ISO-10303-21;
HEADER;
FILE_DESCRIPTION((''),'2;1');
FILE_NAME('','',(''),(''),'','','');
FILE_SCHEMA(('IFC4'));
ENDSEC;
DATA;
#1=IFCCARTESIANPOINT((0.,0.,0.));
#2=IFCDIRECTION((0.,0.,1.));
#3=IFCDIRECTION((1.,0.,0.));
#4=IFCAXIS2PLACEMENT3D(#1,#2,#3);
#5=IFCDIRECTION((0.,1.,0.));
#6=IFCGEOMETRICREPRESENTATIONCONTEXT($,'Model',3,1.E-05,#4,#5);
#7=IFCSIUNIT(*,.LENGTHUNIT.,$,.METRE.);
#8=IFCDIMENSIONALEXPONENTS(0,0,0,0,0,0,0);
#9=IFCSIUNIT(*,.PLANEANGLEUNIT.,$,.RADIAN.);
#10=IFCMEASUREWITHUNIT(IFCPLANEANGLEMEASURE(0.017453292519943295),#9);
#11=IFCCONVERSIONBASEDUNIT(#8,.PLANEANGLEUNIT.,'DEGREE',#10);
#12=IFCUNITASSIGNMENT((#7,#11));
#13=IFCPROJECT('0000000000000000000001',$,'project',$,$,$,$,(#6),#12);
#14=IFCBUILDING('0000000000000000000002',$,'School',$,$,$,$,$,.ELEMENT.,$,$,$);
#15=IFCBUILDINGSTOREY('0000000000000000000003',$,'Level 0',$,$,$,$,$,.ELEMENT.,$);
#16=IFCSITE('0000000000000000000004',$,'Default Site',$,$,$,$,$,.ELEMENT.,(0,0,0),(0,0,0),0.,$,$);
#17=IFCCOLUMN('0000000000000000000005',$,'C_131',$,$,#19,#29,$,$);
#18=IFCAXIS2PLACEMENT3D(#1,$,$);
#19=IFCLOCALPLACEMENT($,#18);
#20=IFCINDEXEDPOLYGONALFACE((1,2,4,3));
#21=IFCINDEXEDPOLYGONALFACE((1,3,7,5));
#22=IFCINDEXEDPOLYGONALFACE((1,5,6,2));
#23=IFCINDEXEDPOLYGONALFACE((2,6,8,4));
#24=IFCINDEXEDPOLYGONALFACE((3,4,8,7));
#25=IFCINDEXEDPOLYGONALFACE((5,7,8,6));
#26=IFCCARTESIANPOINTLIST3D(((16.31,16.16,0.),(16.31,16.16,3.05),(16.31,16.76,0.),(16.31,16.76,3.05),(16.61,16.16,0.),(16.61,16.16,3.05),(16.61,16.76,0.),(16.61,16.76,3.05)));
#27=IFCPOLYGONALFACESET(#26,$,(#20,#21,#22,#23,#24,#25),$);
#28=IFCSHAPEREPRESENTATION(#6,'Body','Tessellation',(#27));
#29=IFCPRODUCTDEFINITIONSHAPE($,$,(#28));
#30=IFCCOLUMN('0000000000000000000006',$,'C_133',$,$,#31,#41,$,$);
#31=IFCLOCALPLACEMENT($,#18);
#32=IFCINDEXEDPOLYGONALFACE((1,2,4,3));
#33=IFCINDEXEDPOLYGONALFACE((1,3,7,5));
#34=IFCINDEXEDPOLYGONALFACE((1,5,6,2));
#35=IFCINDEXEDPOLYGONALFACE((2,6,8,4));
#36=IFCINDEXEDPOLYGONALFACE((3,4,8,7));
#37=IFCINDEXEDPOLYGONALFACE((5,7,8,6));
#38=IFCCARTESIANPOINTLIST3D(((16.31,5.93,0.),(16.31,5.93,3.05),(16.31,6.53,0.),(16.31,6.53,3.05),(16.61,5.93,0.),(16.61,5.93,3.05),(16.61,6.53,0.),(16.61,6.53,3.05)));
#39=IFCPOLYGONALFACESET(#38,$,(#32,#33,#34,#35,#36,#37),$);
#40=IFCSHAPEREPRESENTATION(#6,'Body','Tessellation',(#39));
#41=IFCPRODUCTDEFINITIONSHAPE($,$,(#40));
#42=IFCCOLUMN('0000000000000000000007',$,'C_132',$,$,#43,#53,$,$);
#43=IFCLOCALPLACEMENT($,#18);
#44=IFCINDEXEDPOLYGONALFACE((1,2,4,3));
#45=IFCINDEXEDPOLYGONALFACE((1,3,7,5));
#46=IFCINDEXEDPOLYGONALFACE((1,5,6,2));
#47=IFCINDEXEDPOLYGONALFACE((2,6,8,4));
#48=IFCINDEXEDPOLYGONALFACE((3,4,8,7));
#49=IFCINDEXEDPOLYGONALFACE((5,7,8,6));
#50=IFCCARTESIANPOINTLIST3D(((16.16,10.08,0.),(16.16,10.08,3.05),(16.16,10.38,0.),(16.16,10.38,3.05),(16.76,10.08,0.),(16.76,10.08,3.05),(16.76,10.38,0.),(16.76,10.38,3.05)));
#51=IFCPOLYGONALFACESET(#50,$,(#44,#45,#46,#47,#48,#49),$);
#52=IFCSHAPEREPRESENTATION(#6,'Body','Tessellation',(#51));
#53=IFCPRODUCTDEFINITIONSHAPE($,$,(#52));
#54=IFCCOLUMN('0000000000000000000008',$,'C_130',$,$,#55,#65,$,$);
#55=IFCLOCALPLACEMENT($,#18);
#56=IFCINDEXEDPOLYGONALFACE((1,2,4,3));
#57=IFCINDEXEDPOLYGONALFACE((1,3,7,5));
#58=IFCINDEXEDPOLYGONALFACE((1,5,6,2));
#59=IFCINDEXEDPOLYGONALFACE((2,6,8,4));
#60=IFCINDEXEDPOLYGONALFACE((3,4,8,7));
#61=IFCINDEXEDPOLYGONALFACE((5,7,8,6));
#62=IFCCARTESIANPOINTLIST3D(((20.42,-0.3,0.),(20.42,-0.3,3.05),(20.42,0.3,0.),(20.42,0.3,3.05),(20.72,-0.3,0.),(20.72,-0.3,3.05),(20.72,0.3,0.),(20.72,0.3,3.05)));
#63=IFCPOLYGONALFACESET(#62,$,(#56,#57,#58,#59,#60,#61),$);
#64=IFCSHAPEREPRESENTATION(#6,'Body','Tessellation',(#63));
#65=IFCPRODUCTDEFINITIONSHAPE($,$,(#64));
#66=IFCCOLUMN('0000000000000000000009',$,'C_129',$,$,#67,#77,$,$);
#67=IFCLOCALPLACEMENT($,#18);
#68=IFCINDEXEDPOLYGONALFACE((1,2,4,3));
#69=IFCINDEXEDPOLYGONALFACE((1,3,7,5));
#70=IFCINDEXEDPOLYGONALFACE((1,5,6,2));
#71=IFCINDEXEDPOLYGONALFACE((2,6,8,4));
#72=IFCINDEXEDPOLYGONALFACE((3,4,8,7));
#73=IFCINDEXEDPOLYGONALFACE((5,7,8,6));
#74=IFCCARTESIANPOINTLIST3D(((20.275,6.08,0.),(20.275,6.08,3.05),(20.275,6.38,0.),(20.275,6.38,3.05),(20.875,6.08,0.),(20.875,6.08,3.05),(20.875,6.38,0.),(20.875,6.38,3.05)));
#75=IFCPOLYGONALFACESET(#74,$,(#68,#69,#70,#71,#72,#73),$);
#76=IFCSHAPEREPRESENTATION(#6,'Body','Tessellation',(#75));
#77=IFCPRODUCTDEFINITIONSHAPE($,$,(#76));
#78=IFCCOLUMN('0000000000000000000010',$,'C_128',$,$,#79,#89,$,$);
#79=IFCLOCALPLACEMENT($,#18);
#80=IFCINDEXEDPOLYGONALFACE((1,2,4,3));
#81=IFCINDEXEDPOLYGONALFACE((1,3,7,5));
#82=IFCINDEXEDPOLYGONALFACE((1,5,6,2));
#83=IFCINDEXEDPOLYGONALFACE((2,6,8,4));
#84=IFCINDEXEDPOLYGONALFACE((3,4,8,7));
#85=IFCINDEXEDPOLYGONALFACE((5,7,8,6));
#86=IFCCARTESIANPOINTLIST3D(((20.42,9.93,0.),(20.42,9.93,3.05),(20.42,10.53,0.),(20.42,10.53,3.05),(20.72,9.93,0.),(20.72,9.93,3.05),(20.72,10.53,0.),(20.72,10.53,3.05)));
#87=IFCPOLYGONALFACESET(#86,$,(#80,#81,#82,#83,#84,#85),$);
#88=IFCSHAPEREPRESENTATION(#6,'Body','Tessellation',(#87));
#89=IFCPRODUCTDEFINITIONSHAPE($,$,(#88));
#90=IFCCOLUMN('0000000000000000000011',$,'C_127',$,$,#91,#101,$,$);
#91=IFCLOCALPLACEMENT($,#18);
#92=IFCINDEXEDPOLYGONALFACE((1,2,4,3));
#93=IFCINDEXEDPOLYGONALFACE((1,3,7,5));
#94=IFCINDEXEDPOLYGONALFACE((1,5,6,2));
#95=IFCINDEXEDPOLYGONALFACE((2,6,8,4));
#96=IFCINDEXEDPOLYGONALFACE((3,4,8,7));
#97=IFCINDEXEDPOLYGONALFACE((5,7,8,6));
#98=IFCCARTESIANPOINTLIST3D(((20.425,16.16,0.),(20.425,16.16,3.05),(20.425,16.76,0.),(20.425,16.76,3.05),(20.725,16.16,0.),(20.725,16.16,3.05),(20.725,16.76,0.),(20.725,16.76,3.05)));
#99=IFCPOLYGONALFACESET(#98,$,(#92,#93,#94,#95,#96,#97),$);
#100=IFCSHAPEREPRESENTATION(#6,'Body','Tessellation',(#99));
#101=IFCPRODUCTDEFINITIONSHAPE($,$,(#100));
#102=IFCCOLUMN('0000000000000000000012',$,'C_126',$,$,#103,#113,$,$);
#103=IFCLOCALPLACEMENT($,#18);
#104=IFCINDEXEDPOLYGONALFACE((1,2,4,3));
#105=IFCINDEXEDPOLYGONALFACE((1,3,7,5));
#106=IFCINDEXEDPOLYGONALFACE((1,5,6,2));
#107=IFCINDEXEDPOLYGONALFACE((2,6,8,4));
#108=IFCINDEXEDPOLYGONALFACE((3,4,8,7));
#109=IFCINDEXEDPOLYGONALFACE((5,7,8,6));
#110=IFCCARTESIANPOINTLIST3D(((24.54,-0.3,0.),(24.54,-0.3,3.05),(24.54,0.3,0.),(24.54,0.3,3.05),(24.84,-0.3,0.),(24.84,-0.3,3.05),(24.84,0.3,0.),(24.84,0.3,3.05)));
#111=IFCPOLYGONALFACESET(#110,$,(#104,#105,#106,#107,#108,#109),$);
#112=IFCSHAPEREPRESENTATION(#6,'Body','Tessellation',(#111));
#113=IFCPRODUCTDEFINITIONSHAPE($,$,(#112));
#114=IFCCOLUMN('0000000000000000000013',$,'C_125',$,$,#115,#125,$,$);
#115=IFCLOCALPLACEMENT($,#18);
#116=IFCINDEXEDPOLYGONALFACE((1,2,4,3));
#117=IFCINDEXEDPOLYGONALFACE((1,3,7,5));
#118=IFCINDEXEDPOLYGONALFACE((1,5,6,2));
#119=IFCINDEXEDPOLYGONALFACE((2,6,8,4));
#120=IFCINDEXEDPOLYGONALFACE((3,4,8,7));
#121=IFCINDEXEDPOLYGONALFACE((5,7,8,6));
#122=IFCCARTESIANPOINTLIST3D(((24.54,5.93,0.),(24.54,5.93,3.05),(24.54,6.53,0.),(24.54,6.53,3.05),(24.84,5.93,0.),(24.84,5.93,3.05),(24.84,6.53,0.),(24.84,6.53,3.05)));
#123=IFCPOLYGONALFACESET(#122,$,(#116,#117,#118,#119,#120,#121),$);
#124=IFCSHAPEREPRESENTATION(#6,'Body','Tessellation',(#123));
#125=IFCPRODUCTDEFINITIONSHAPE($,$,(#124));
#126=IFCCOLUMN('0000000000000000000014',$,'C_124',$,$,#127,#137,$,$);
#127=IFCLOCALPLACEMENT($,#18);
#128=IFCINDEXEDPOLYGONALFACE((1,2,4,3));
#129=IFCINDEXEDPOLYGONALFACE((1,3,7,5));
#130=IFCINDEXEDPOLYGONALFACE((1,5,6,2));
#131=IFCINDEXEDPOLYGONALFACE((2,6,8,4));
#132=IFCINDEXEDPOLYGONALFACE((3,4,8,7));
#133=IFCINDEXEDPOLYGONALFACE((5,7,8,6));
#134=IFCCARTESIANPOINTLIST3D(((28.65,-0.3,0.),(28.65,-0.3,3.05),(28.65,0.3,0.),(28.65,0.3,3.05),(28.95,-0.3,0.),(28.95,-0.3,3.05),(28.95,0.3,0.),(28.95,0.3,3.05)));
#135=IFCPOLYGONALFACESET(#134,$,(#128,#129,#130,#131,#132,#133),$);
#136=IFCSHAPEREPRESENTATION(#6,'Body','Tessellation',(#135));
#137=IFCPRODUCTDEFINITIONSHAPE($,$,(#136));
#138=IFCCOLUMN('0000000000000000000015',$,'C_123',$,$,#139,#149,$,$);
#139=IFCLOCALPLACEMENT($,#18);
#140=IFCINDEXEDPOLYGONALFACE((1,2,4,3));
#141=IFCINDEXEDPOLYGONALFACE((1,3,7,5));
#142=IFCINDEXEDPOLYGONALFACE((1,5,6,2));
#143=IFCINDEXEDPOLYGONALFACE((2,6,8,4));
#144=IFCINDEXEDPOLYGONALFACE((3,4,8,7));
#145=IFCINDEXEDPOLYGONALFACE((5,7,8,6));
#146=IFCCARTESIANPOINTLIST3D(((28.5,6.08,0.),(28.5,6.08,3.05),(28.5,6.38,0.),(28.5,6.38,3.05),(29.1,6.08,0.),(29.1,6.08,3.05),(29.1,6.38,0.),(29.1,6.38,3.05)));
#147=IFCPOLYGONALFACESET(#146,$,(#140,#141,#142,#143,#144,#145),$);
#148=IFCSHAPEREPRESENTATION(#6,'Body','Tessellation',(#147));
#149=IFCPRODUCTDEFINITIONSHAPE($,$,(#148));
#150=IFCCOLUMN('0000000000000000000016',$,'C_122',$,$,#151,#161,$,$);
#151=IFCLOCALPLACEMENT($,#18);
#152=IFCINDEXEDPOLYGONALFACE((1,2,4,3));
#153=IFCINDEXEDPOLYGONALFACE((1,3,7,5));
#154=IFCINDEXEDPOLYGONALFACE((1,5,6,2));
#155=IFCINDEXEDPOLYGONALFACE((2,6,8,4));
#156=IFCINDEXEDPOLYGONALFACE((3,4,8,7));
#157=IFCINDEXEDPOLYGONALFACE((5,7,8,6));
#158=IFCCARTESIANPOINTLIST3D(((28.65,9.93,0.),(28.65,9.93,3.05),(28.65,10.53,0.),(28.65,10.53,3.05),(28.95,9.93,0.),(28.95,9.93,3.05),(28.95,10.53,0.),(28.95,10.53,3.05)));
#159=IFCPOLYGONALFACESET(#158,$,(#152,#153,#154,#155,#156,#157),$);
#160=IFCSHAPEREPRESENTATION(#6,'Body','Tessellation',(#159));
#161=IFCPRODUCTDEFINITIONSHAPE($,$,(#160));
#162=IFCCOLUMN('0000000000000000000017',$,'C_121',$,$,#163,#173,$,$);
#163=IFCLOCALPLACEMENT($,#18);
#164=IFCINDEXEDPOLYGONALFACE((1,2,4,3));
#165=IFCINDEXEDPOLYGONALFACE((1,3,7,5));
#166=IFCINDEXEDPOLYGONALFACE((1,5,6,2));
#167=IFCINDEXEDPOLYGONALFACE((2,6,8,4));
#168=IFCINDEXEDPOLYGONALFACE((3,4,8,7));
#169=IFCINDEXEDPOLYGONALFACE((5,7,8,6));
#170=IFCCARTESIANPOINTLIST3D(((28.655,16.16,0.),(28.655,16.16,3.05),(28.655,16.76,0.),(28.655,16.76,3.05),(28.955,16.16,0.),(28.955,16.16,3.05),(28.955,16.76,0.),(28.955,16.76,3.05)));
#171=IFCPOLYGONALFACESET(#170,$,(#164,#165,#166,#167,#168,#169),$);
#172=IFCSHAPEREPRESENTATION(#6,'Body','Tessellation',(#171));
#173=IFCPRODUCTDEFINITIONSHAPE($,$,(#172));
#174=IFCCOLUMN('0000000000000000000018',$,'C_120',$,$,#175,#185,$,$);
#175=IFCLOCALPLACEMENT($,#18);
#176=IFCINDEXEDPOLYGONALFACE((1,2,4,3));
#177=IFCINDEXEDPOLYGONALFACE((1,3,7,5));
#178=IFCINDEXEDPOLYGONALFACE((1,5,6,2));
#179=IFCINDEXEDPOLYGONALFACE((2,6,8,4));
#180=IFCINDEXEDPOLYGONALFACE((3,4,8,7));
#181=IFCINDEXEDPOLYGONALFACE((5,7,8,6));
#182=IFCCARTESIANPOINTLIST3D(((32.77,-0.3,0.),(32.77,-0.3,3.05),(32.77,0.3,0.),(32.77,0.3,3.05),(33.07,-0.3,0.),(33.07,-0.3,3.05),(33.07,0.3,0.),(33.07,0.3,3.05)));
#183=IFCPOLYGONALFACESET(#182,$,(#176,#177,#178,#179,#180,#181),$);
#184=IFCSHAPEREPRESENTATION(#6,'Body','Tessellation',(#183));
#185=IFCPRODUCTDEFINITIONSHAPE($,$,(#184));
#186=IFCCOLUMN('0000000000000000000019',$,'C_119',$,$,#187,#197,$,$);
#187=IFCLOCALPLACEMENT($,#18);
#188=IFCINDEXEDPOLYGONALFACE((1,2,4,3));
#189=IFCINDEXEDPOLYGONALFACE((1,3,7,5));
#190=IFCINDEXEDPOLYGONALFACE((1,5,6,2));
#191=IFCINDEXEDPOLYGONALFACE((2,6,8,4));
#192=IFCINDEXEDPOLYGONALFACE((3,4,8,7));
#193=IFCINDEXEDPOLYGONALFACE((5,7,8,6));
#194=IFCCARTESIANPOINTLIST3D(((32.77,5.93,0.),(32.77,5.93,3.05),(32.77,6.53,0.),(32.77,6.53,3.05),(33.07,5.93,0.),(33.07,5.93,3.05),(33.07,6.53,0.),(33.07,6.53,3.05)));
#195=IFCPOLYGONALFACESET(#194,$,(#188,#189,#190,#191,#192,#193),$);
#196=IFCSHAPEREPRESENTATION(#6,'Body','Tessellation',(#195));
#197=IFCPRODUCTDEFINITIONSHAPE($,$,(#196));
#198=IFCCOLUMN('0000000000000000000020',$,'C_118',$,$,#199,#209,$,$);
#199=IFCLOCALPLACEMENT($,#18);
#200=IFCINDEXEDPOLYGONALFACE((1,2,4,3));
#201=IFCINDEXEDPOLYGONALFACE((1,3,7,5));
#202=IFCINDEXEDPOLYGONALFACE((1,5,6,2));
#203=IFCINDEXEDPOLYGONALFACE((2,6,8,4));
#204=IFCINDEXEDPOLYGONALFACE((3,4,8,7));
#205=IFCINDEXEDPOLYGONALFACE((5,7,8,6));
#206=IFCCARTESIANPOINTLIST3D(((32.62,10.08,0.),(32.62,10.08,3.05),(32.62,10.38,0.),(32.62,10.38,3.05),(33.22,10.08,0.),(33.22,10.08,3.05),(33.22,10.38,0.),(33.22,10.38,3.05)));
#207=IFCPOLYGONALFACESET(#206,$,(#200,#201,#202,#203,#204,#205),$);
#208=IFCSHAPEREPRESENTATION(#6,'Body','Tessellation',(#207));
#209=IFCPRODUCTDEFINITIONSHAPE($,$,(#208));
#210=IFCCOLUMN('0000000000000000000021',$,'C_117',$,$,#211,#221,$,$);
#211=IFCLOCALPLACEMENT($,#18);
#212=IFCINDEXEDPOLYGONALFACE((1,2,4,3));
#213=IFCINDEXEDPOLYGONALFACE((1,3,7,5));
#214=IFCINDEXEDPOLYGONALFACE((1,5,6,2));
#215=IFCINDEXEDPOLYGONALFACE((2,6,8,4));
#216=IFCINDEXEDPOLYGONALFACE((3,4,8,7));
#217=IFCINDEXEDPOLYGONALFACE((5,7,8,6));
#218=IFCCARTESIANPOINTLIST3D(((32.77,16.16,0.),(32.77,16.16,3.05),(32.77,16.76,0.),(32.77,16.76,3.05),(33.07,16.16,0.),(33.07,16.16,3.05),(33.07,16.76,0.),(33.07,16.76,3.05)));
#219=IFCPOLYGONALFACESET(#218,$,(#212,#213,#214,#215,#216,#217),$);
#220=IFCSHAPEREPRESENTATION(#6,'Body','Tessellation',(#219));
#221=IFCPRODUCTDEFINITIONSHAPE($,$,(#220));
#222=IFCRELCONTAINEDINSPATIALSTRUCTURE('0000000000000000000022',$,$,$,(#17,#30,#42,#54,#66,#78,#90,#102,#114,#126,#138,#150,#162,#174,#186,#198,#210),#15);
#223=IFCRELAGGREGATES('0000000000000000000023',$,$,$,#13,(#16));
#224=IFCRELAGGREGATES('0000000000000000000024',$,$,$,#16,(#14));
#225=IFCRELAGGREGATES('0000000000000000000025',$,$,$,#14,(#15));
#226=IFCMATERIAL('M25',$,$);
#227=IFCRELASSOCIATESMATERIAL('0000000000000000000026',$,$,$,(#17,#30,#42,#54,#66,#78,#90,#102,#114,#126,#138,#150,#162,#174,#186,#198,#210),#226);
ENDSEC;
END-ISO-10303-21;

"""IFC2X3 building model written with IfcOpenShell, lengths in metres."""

from ifc_helpers import new_model, entity, si_unit, converted_unit, direction, frame, frame_2d, origin_with_axes, place, context, project, spatial, rectangle, extrude, material, element, save


model = new_model("IFC2X3")

# Units and contexts
model_context = context("Model", 3, precision=1e-05, world=origin_with_axes(), true_north=direction((0.0, 1.0, 0.0)))
ifc_project = project(units=[si_unit("LENGTHUNIT", "METRE"), converted_unit("PLANEANGLEUNIT", "DEGREE", entity("IfcPlaneAngleMeasure", 0.017453292519943295), si_unit("PLANEANGLEUNIT", "RADIAN"), dimensions=[0, 0, 0, 0, 0, 0, 0])], contexts=[model_context])

# Site, building, storey
site = spatial("IfcSite", under=ifc_project, Name="Default Site", CompositionType="ELEMENT", RefLatitude=(0, 0, 0), RefLongitude=(0, 0, 0), RefElevation=0.0)
building = spatial("IfcBuilding", under=site, Name="School", CompositionType="ELEMENT")
storey = spatial("IfcBuildingStorey", under=building, Name="Level 0", CompositionType="ELEMENT")

# Columns
ifc_material = material(Name="M25")
placement = place(None, origin_with_axes())
element("IfcColumn", 1, at=placement, inside=storey, material=ifc_material, Name="C_131", context=model_context, shape_type="SweptSolid", body=[
    extrude(rectangle(XDim=0.3, YDim=0.6, at=frame_2d((0.0, 0.0), x_axis=(1.0, 0.0, 0.0))), frame((16.46, 16.46, 0.0), z_axis=(0.0, 0.0, 1.0), x_axis=(1.0, 0.0, 0.0)), (0.0, 0.0, 1.0), 3.05),
])
element("IfcColumn", 2, at=placement, inside=storey, material=ifc_material, Name="C_133", context=model_context, shape_type="SweptSolid", body=[
    extrude(rectangle(XDim=0.3, YDim=0.6, at=frame_2d((0.0, 0.0), x_axis=(1.0, 0.0, 0.0))), frame((16.46, 6.23, 0.0), z_axis=(0.0, 0.0, 1.0), x_axis=(1.0, 0.0, 0.0)), (0.0, 0.0, 1.0), 3.05),
])
element("IfcColumn", 3, at=placement, inside=storey, material=ifc_material, Name="C_132", context=model_context, shape_type="SweptSolid", body=[
    extrude(rectangle(XDim=0.6, YDim=0.3, at=frame_2d((0.0, 0.0), x_axis=(1.0, 0.0, 0.0))), frame((16.46, 10.23, 0.0), z_axis=(0.0, 0.0, 1.0), x_axis=(1.0, 0.0, 0.0)), (0.0, 0.0, 1.0), 3.05),
])
element("IfcColumn", 4, at=placement, inside=storey, material=ifc_material, Name="C_130", context=model_context, shape_type="SweptSolid", body=[
    extrude(rectangle(XDim=0.3, YDim=0.6, at=frame_2d((0.0, 0.0), x_axis=(1.0, 0.0, 0.0))), frame((20.57, 0.0, 0.0), z_axis=(0.0, 0.0, 1.0), x_axis=(1.0, 0.0, 0.0)), (0.0, 0.0, 1.0), 3.05),
])
element("IfcColumn", 5, at=placement, inside=storey, material=ifc_material, Name="C_129", context=model_context, shape_type="SweptSolid", body=[
    extrude(rectangle(XDim=0.6, YDim=0.3, at=frame_2d((0.0, 0.0), x_axis=(1.0, 0.0, 0.0))), frame((20.575, 6.23, 0.0), z_axis=(0.0, 0.0, 1.0), x_axis=(1.0, 0.0, 0.0)), (0.0, 0.0, 1.0), 3.05),
])
element("IfcColumn", 6, at=placement, inside=storey, material=ifc_material, Name="C_128", context=model_context, shape_type="SweptSolid", body=[
    extrude(rectangle(XDim=0.3, YDim=0.6, at=frame_2d((0.0, 0.0), x_axis=(1.0, 0.0, 0.0))), frame((20.57, 10.23, 0.0), z_axis=(0.0, 0.0, 1.0), x_axis=(1.0, 0.0, 0.0)), (0.0, 0.0, 1.0), 3.05),
])
element("IfcColumn", 7, at=placement, inside=storey, material=ifc_material, Name="C_127", context=model_context, shape_type="SweptSolid", body=[
    extrude(rectangle(XDim=0.3, YDim=0.6, at=frame_2d((0.0, 0.0), x_axis=(1.0, 0.0, 0.0))), frame((20.575, 16.46, 0.0), z_axis=(0.0, 0.0, 1.0), x_axis=(1.0, 0.0, 0.0)), (0.0, 0.0, 1.0), 3.05),
])
element("IfcColumn", 8, at=placement, inside=storey, material=ifc_material, Name="C_126", context=model_context, shape_type="SweptSolid", body=[
    extrude(rectangle(XDim=0.3, YDim=0.6, at=frame_2d((0.0, 0.0), x_axis=(1.0, 0.0, 0.0))), frame((24.69, 0.0, 0.0), z_axis=(0.0, 0.0, 1.0), x_axis=(1.0, 0.0, 0.0)), (0.0, 0.0, 1.0), 3.05),
])
element("IfcColumn", 9, at=placement, inside=storey, material=ifc_material, Name="C_125", context=model_context, shape_type="SweptSolid", body=[
    extrude(rectangle(XDim=0.3, YDim=0.6, at=frame_2d((0.0, 0.0), x_axis=(1.0, 0.0, 0.0))), frame((24.69, 6.23, 0.0), z_axis=(0.0, 0.0, 1.0), x_axis=(1.0, 0.0, 0.0)), (0.0, 0.0, 1.0), 3.05),
])
element("IfcColumn", 10, at=placement, inside=storey, material=ifc_material, Name="C_124", context=model_context, shape_type="SweptSolid", body=[
    extrude(rectangle(XDim=0.3, YDim=0.6, at=frame_2d((0.0, 0.0), x_axis=(1.0, 0.0, 0.0))), frame((28.8, 0.0, 0.0), z_axis=(0.0, 0.0, 1.0), x_axis=(1.0, 0.0, 0.0)), (0.0, 0.0, 1.0), 3.05),
])
element("IfcColumn", 11, at=placement, inside=storey, material=ifc_material, Name="C_123", context=model_context, shape_type="SweptSolid", body=[
    extrude(rectangle(XDim=0.6, YDim=0.3, at=frame_2d((0.0, 0.0), x_axis=(1.0, 0.0, 0.0))), frame((28.8, 6.23, 0.0), z_axis=(0.0, 0.0, 1.0), x_axis=(1.0, 0.0, 0.0)), (0.0, 0.0, 1.0), 3.05),
])
element("IfcColumn", 12, at=placement, inside=storey, material=ifc_material, Name="C_122", context=model_context, shape_type="SweptSolid", body=[
    extrude(rectangle(XDim=0.3, YDim=0.6, at=frame_2d((0.0, 0.0), x_axis=(1.0, 0.0, 0.0))), frame((28.8, 10.23, 0.0), z_axis=(0.0, 0.0, 1.0), x_axis=(1.0, 0.0, 0.0)), (0.0, 0.0, 1.0), 3.05),
])
element("IfcColumn", 13, at=placement, inside=storey, material=ifc_material, Name="C_121", context=model_context, shape_type="SweptSolid", body=[
    extrude(rectangle(XDim=0.3, YDim=0.6, at=frame_2d((0.0, 0.0), x_axis=(1.0, 0.0, 0.0))), frame((28.805, 16.46, 0.0), z_axis=(0.0, 0.0, 1.0), x_axis=(1.0, 0.0, 0.0)), (0.0, 0.0, 1.0), 3.05),
])
element("IfcColumn", 14, at=placement, inside=storey, material=ifc_material, Name="C_120", context=model_context, shape_type="SweptSolid", body=[
    extrude(rectangle(XDim=0.3, YDim=0.6, at=frame_2d((0.0, 0.0), x_axis=(1.0, 0.0, 0.0))), frame((32.92, 0.0, 0.0), z_axis=(0.0, 0.0, 1.0), x_axis=(1.0, 0.0, 0.0)), (0.0, 0.0, 1.0), 3.05),
])
element("IfcColumn", 15, at=placement, inside=storey, material=ifc_material, Name="C_119", context=model_context, shape_type="SweptSolid", body=[
    extrude(rectangle(XDim=0.3, YDim=0.6, at=frame_2d((0.0, 0.0), x_axis=(1.0, 0.0, 0.0))), frame((32.92, 6.23, 0.0), z_axis=(0.0, 0.0, 1.0), x_axis=(1.0, 0.0, 0.0)), (0.0, 0.0, 1.0), 3.05),
])
element("IfcColumn", 16, at=placement, inside=storey, material=ifc_material, Name="C_118", context=model_context, shape_type="SweptSolid", body=[
    extrude(rectangle(XDim=0.6, YDim=0.3, at=frame_2d((0.0, 0.0), x_axis=(1.0, 0.0, 0.0))), frame((32.92, 10.23, 0.0), z_axis=(0.0, 0.0, 1.0), x_axis=(1.0, 0.0, 0.0)), (0.0, 0.0, 1.0), 3.05),
])
element("IfcColumn", 17, at=placement, inside=storey, material=ifc_material, Name="C_117", context=model_context, shape_type="SweptSolid", body=[
    extrude(rectangle(XDim=0.3, YDim=0.6, at=frame_2d((0.0, 0.0), x_axis=(1.0, 0.0, 0.0))), frame((32.92, 16.46, 0.0), z_axis=(0.0, 0.0, 1.0), x_axis=(1.0, 0.0, 0.0)), (0.0, 0.0, 1.0), 3.05),
])

save(model, "model.ifc")
